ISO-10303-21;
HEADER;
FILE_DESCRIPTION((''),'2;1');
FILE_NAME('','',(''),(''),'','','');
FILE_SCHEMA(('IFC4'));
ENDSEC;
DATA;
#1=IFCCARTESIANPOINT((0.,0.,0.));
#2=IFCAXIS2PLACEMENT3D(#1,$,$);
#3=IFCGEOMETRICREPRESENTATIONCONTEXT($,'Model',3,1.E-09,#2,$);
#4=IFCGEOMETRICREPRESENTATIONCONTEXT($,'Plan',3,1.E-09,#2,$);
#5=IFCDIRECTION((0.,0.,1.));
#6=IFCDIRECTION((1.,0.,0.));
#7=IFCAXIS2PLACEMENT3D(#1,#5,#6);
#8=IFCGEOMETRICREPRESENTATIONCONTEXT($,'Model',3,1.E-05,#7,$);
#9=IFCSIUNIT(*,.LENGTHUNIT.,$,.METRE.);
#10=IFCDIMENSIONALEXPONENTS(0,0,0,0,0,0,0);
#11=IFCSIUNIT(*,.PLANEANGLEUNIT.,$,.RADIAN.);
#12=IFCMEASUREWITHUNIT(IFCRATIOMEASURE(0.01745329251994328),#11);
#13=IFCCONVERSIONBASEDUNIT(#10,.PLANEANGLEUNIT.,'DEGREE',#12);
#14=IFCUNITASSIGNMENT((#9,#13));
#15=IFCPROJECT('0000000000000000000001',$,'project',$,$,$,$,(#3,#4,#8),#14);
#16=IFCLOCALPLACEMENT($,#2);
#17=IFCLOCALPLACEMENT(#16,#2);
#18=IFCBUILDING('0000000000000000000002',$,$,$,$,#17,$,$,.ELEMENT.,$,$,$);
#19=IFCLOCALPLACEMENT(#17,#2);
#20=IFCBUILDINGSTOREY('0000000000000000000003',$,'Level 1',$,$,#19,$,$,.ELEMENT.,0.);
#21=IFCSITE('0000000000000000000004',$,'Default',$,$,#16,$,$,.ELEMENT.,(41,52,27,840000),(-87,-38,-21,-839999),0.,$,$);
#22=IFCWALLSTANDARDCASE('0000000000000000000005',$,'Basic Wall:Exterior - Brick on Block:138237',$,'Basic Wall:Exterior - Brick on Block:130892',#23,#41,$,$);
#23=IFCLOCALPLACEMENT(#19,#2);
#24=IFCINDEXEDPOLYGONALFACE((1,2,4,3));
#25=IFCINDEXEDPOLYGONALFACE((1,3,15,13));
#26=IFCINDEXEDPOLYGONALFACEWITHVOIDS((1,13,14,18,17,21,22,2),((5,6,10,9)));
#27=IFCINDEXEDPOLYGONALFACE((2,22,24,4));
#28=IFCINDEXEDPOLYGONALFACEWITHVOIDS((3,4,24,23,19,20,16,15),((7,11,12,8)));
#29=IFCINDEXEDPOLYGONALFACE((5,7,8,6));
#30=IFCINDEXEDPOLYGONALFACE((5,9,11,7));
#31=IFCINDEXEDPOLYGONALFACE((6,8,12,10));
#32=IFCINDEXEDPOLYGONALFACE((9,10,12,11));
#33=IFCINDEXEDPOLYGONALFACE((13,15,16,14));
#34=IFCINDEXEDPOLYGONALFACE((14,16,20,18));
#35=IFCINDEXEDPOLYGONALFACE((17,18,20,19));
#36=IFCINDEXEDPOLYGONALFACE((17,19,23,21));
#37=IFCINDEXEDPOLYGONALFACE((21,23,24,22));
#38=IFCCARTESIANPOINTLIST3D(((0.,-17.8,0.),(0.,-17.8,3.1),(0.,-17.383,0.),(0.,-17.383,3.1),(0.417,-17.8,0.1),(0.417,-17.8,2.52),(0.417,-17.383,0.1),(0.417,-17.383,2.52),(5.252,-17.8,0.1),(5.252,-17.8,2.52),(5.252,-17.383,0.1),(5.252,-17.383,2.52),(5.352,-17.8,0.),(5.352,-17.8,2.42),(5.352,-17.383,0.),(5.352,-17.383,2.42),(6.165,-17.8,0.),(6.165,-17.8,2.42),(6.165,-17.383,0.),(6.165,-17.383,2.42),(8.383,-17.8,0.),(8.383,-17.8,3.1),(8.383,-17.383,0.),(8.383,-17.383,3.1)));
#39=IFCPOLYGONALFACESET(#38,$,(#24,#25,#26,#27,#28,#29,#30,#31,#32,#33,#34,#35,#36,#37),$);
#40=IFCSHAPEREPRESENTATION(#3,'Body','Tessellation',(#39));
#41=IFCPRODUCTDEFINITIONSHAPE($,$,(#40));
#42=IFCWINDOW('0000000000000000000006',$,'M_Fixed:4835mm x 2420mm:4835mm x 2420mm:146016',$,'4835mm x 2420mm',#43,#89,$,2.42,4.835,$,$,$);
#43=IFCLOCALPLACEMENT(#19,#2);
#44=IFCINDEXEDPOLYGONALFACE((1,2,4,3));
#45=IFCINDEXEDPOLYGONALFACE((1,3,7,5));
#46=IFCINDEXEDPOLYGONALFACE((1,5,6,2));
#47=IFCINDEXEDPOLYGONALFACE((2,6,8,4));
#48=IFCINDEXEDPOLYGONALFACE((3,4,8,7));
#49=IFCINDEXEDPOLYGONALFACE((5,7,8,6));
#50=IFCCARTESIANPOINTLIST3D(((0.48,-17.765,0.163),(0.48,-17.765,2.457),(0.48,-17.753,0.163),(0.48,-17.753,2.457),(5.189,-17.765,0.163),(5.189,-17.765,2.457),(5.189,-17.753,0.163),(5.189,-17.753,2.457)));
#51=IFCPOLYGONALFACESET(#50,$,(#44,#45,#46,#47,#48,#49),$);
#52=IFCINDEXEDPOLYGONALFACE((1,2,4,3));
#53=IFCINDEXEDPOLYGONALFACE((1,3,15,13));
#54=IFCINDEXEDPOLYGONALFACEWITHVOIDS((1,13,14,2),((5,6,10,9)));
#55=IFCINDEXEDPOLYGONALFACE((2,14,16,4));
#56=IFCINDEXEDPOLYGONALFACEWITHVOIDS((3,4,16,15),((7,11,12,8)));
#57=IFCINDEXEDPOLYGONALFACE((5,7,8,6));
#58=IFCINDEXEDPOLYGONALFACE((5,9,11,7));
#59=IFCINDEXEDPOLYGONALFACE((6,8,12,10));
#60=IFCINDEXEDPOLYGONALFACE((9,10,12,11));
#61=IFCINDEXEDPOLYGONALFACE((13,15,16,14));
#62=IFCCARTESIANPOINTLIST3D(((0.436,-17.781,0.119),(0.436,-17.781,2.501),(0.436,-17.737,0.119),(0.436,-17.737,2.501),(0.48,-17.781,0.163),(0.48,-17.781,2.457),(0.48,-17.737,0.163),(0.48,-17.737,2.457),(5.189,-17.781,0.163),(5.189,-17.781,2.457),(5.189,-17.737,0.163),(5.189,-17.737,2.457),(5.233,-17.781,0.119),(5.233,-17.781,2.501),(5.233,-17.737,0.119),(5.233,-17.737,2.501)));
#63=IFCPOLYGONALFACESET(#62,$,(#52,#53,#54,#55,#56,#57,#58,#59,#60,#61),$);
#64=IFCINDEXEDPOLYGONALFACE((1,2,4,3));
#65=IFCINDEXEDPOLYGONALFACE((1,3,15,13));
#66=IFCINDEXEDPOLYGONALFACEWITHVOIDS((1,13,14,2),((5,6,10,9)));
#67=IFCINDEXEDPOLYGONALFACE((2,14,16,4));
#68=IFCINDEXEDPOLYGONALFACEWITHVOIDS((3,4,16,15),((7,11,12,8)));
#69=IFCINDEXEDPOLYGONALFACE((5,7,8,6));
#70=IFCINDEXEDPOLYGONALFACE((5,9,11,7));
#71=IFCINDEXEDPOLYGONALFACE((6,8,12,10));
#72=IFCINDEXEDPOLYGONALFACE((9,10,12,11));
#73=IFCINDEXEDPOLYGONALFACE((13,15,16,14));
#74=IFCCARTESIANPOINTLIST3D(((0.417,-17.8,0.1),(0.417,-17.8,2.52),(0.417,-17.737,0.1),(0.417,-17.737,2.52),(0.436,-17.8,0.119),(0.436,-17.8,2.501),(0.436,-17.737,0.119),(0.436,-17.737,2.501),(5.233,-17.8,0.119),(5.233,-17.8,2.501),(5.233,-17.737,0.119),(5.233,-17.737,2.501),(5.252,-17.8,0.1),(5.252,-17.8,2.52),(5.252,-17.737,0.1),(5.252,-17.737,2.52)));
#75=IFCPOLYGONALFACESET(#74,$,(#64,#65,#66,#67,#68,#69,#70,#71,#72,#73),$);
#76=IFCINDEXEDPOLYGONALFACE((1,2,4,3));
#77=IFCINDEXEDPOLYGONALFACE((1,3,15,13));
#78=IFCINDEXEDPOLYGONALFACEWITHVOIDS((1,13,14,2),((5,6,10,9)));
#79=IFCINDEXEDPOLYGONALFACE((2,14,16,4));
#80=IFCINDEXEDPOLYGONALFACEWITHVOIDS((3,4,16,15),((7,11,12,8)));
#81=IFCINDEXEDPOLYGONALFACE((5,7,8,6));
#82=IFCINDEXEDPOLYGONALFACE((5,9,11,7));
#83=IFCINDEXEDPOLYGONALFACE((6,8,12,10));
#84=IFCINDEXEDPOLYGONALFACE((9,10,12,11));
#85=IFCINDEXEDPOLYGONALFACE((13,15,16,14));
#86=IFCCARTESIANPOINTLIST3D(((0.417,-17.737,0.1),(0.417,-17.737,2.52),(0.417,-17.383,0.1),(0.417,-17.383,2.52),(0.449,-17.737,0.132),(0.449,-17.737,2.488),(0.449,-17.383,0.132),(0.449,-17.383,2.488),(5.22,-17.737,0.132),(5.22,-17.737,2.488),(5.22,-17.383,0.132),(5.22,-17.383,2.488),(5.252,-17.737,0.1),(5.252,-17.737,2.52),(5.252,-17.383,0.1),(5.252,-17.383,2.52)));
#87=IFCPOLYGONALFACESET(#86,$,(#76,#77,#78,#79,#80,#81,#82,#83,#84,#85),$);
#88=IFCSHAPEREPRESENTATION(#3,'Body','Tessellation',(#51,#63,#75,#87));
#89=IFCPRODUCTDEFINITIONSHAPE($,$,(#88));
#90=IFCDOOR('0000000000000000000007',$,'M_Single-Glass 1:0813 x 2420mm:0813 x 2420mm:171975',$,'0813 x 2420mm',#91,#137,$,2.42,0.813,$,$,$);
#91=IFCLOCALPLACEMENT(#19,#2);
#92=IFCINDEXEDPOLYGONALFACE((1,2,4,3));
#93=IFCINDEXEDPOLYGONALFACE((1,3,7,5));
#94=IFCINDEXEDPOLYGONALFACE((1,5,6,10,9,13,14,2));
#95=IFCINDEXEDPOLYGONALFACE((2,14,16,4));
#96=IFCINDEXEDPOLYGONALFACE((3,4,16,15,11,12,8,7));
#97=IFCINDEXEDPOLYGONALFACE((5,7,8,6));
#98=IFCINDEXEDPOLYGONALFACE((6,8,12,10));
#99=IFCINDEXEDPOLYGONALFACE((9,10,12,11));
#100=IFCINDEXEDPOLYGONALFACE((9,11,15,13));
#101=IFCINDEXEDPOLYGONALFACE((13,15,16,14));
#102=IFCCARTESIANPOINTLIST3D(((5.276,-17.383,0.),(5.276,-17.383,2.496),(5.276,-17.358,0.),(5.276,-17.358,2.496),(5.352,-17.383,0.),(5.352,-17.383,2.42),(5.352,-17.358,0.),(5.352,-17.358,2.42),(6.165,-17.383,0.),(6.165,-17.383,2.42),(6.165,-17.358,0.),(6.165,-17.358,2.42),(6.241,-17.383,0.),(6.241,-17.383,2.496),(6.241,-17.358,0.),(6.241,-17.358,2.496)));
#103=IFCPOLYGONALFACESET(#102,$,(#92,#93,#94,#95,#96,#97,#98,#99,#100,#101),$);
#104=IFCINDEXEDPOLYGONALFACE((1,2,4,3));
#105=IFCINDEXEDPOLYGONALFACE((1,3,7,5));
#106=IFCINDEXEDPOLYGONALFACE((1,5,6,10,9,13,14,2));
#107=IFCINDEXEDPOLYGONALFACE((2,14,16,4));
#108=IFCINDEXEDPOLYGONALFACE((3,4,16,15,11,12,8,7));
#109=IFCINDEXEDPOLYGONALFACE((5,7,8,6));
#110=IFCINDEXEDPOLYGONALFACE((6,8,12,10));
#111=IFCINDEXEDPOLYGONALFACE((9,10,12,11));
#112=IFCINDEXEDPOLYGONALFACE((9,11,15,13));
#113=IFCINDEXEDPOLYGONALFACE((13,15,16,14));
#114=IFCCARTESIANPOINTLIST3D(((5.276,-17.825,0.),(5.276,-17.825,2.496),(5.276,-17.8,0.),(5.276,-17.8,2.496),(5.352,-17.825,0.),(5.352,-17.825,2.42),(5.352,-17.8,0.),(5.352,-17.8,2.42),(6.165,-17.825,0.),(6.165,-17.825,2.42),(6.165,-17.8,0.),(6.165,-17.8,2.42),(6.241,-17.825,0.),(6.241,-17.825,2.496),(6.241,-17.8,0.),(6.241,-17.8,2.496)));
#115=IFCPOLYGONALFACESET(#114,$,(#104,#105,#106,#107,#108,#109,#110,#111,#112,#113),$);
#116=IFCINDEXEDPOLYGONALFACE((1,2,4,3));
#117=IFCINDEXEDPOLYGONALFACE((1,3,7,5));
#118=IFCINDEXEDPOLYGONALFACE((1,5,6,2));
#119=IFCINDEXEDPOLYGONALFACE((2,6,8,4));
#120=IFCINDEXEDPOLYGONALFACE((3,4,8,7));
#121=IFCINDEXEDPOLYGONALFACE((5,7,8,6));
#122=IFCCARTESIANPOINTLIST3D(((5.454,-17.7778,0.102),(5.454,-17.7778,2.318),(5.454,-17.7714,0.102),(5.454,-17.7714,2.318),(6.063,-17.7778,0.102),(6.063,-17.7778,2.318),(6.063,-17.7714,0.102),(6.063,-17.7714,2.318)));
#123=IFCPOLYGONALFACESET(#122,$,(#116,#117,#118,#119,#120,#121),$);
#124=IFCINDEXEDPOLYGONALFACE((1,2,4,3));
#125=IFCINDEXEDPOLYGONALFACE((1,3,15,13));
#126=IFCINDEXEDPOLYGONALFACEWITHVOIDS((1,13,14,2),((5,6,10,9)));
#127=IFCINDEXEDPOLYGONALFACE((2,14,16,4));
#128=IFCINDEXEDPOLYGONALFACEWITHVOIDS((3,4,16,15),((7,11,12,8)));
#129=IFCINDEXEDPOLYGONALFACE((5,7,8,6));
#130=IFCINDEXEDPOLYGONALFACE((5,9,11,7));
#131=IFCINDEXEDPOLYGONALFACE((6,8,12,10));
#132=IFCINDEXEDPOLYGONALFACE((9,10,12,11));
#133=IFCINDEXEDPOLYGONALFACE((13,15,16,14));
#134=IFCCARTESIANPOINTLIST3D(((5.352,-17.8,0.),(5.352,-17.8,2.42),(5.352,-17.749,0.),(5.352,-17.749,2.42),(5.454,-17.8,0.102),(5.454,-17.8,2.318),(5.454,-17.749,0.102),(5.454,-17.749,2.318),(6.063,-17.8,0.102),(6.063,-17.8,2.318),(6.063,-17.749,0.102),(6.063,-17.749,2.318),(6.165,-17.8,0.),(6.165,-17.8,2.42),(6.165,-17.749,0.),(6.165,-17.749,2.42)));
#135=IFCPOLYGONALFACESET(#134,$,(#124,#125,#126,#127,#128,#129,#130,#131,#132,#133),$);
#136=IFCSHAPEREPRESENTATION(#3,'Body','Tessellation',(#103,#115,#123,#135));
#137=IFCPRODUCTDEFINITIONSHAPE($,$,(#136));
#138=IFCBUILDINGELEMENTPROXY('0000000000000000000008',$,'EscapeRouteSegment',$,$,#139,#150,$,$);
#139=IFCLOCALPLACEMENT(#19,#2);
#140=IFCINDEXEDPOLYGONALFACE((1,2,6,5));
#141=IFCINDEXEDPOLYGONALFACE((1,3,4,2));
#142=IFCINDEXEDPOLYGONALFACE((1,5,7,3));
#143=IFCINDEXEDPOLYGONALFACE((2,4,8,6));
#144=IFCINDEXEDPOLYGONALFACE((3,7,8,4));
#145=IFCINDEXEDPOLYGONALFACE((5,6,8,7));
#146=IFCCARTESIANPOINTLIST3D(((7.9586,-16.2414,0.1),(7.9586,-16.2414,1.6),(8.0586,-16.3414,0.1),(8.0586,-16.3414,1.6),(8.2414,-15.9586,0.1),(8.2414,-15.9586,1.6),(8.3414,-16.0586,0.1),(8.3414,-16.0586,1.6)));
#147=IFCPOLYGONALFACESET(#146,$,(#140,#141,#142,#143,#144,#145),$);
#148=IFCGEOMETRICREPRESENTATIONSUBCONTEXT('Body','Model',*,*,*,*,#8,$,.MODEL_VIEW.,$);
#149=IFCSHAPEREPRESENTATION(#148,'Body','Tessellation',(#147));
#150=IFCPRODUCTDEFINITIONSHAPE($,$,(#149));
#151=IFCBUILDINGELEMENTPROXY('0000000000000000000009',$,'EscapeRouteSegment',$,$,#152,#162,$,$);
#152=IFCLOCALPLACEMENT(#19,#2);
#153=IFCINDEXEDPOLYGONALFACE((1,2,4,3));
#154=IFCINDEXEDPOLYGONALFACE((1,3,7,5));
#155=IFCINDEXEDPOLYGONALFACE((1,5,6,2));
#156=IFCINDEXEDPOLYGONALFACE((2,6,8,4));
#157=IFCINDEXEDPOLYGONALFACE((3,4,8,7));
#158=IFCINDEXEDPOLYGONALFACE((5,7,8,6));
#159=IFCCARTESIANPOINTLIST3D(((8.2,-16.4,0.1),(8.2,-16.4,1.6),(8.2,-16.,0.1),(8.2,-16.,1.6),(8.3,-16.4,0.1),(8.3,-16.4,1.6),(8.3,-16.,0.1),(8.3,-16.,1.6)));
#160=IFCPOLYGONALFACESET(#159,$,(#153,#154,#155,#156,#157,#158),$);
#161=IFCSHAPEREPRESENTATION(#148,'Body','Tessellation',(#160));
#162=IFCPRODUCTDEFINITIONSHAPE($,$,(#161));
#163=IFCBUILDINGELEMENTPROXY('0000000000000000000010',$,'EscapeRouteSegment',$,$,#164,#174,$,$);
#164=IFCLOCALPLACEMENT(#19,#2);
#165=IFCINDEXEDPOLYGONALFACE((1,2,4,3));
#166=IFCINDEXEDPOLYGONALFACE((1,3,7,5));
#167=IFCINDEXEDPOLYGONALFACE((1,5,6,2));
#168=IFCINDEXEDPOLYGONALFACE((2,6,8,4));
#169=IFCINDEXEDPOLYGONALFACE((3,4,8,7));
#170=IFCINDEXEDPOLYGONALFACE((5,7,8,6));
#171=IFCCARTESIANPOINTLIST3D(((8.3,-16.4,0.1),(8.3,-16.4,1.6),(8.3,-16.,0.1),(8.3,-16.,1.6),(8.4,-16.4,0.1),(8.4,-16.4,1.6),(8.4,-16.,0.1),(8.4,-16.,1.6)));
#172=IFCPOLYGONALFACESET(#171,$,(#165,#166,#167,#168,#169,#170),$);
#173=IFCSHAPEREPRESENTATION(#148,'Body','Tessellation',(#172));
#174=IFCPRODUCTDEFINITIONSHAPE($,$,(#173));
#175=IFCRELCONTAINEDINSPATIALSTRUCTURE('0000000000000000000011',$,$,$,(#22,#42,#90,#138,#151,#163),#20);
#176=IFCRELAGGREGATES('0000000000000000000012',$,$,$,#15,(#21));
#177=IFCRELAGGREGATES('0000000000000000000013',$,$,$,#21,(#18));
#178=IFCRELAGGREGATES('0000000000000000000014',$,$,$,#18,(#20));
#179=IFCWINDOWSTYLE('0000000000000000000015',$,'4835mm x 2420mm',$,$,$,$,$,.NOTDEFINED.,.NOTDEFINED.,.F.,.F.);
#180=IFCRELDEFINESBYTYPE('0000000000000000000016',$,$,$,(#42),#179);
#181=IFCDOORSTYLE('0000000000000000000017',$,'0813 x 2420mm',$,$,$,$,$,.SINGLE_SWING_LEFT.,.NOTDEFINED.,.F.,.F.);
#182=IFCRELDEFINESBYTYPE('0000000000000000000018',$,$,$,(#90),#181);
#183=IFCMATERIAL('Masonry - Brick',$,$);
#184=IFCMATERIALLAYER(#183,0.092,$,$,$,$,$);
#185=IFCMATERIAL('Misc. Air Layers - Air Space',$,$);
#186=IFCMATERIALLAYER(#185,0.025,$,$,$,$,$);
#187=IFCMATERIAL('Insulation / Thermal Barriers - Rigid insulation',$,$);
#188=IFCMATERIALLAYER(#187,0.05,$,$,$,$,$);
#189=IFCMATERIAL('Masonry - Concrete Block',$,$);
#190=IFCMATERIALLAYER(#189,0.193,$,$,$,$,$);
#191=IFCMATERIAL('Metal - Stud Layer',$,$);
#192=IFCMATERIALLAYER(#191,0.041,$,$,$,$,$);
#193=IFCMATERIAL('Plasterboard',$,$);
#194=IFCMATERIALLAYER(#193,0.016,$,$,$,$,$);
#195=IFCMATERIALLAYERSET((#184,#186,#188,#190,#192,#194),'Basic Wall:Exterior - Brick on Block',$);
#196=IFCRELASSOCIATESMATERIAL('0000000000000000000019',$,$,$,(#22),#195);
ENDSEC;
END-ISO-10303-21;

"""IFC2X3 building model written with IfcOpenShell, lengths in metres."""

from ifc_helpers import new_model, entity, si_unit, converted_unit, frame, frame_2d, origin, origin_with_axes, origin_2d_with_axis, place, context, subcontext, project, spatial, polyline, rectangle, outline, extrude, source, transform, mapped, material, layer, layer_set, layer_usage, type_object, type_shapes, element, fill, save


model = new_model("IFC2X3")

# Units and contexts
model_context_1 = context("Model", 3, precision=1e-09, world=origin())
plan_context = context("Plan", 3, precision=1e-09, world=origin())
model_context_2 = context("Model", 3, precision=1e-05, world=origin_with_axes())
body_context = subcontext(model_context_2, "Body", "Model", "MODEL_VIEW")
ifc_project = project(units=[si_unit("LENGTHUNIT", "METRE"), converted_unit("PLANEANGLEUNIT", "DEGREE", entity("IfcRatioMeasure", 0.01745329251994328), si_unit("PLANEANGLEUNIT", "RADIAN"), dimensions=[0, 0, 0, 0, 0, 0, 0])], contexts=[model_context_1, plan_context, model_context_2])

# Site, building, storey
site_placement = place(None, origin())
site = spatial("IfcSite", under=ifc_project, at=site_placement, Name="Default", CompositionType="ELEMENT", RefLatitude=(41, 52, 27, 840000), RefLongitude=(-87, -38, -21, -839999), RefElevation=0.0)
building_placement = place(site_placement, origin())
building = spatial("IfcBuilding", under=site, at=building_placement, CompositionType="ELEMENT")
storey_placement = place(building_placement, origin())
storey = spatial("IfcBuildingStorey", under=building, at=storey_placement, Name="Level 1", CompositionType="ELEMENT", Elevation=0.0)

# Wall, openings, window, door
ifc_material_1 = material(Name="Masonry - Brick")
ifc_layer_1 = layer(ifc_material_1, 0.092)
ifc_material_2 = material(Name="Misc. Air Layers - Air Space")
ifc_layer_2 = layer(ifc_material_2, 0.025)
ifc_material_3 = material(Name="Insulation / Thermal Barriers - Rigid insulation")
ifc_layer_3 = layer(ifc_material_3, 0.05)
ifc_material_4 = material(Name="Masonry - Concrete Block")
ifc_layer_4 = layer(ifc_material_4, 0.193)
ifc_material_5 = material(Name="Metal - Stud Layer")
ifc_layer_5 = layer(ifc_material_5, 0.041)
ifc_material_6 = material(Name="Plasterboard")
ifc_layer_6 = layer(ifc_material_6, 0.016)
ifc_layer_set = layer_set([ifc_layer_1, ifc_layer_2, ifc_layer_3, ifc_layer_4, ifc_layer_5, ifc_layer_6], Name="Basic Wall:Exterior - Brick on Block")
ifc_layer_usage = layer_usage(ifc_layer_set, "AXIS2", "NEGATIVE", 0.2085)
wall_placement = place(storey_placement, frame((8.383, -17.5915, 0.0), z_axis=(0.0, 0.0, 1.0), x_axis=(-1.0, 0.0, 0.0)))
wall = element("IfcWallStandardCase", 1, at=wall_placement, inside=storey, material=ifc_layer_usage, Name="Basic Wall:Exterior - Brick on Block:138237", ObjectType="Basic Wall:Exterior - Brick on Block:130892", context=model_context_1, shape_type="SweptSolid", body=[
    extrude(rectangle(XDim=8.383, YDim=0.417, at=frame_2d((4.1915, 0.0), x_axis=(-1.0, 0.0))), origin(), (0.0, 0.0, 1.0), 3.1),
])
opening_1_placement = place(wall_placement, frame((3.131, -0.2085, 0.1)))
opening_1 = element("IfcOpeningElement", 2, at=opening_1_placement, cuts=wall, ObjectType="Opening", context=model_context_1, shape_type="SweptSolid", body=[
    extrude(rectangle(XDim=2.42, YDim=4.835, at=frame_2d((1.21, 2.4175), x_axis=(1.0, 0.0))), frame((0.0, 0.0, 0.0), z_axis=(0.0, 1.0, 0.0), x_axis=(0.0, 0.0, 1.0)), (0.0, 0.0, 1.0), 0.417),
])
opening_2_placement = place(wall_placement, frame((2.218, -0.2085, 0.0)))
opening_2 = element("IfcOpeningElement", 3, at=opening_2_placement, cuts=wall, ObjectType="Opening", context=model_context_1, shape_type="SweptSolid", body=[
    extrude(rectangle(XDim=0.813, YDim=2.42, at=frame_2d((1.21, 0.4065), x_axis=(0.0, -1.0))), frame((0.0, 0.0, 0.0), z_axis=(0.0, 1.0, 0.0), x_axis=(0.0, 0.0, 1.0)), (0.0, 0.0, 1.0), 0.417),
])
window_style = type_object("IfcWindowStyle", Name="4835mm x 2420mm", ConstructionType="NOTDEFINED", OperationType="NOTDEFINED", ParameterTakesPrecedence=False, Sizeable=False)
shared_shape_1 = source(origin(), model_context_1, "Body", "SweptSolid", [
    extrude(rectangle(XDim=0.012, YDim=4.709, at=origin_2d_with_axis()), frame((2.4175, 0.376, 0.063), z_axis=(0.0, 0.0, 1.0), x_axis=(0.0, -1.0, 0.0)), (0.0, 0.0, 1.0), 2.294),
    extrude(outline(polyline([(-2.3985, -1.191), (2.3985, -1.191), (2.3985, 1.191), (-2.3985, 1.191), (-2.3985, -1.191)]), holes=[polyline([(-2.3545, -1.147), (-2.3545, 1.147), (2.3545, 1.147), (2.3545, -1.147), (-2.3545, -1.147)])]), frame((2.4175, 0.354, 1.21), z_axis=(0.0, 1.0, 0.0), x_axis=(1.0, 0.0, 0.0)), (0.0, 0.0, 1.0), 0.044),
    extrude(outline(polyline([(-2.4175, -1.21), (2.4175, -1.21), (2.4175, 1.21), (-2.4175, 1.21), (-2.4175, -1.21)]), holes=[polyline([(-2.3985, -1.191), (-2.3985, 1.191), (2.3985, 1.191), (2.3985, -1.191), (-2.3985, -1.191)])]), frame((2.4175, 0.354, 1.21), z_axis=(0.0, 1.0, 0.0), x_axis=(1.0, 0.0, 0.0)), (0.0, 0.0, 1.0), 0.063),
    extrude(outline(polyline([(-2.4175, -1.21), (2.4175, -1.21), (2.4175, 1.21), (-2.4175, 1.21), (-2.4175, -1.21)]), holes=[polyline([(-2.3855, -1.178), (-2.3855, 1.178), (2.3855, 1.178), (2.3855, -1.178), (-2.3855, -1.178)])]), frame((2.4175, 0.0, 1.21), z_axis=(0.0, 1.0, 0.0), x_axis=(1.0, 0.0, 0.0)), (0.0, 0.0, 1.0), 0.354),
])
type_shapes(window_style, [shared_shape_1])
window_placement = place(opening_1_placement, origin())
window = element("IfcWindow", 4, at=window_placement, inside=storey, type_object=window_style, Name="M_Fixed:4835mm x 2420mm:4835mm x 2420mm:146016", ObjectType="4835mm x 2420mm", OverallHeight=2.42, OverallWidth=4.835, context=model_context_1, shape_type="MappedRepresentation", body=[
    mapped(shared_shape_1, transform((0.0, 0.0, 0.0), scale=1.0)),
])
fill(opening_1, window)
door_style = type_object("IfcDoorStyle", Name="0813 x 2420mm", ConstructionType="NOTDEFINED", OperationType="SINGLE_SWING_LEFT", ParameterTakesPrecedence=False, Sizeable=False)
shared_shape_2 = source(origin(), model_context_1, "Body", "SweptSolid", [
    extrude(outline(polyline([(-0.4065, -1.191), (-0.4065, 1.229), (-0.4825, 1.229), (-0.4825, -1.267), (0.4825, -1.267), (0.4825, 1.229), (0.4065, 1.229), (0.4065, -1.191), (-0.4065, -1.191)])), frame((0.4065, 0.0, 1.229), z_axis=(0.0, 1.0, 0.0), x_axis=(1.0, 0.0, 0.0)), (0.0, 0.0, -1.0), 0.025),
    extrude(outline(polyline([(-0.4065, -1.191), (-0.4065, 1.229), (-0.4825, 1.229), (-0.4825, -1.267), (0.4825, -1.267), (0.4825, 1.229), (0.4065, 1.229), (0.4065, -1.191), (-0.4065, -1.191)])), frame((0.4065, 0.442, 1.229), z_axis=(0.0, 1.0, 0.0), x_axis=(1.0, 0.0, 0.0)), (0.0, 0.0, -1.0), 0.025),
    extrude(rectangle(XDim=0.609, YDim=0.0064, at=origin_2d_with_axis()), frame((0.4065, 0.3916, 0.102)), (0.0, 0.0, 1.0), 2.216),
    extrude(outline(polyline([(-1.21, -0.4065), (1.21, -0.4065), (1.21, 0.4065), (-1.21, 0.4065), (-1.21, -0.4065)]), holes=[polyline([(-1.108, 0.3045), (1.108, 0.3045), (1.108, -0.3045), (-1.108, -0.3045), (-1.108, 0.3045)])]), frame((0.4065, 0.417, 1.21), z_axis=(0.0, -1.0, 0.0), x_axis=(0.0, 0.0, -1.0)), (0.0, 0.0, 1.0), 0.051),
])
type_shapes(door_style, [shared_shape_2])
door_placement = place(opening_2_placement, origin())
door = element("IfcDoor", 5, at=door_placement, inside=storey, type_object=door_style, Name="M_Single-Glass 1:0813 x 2420mm:0813 x 2420mm:171975", ObjectType="0813 x 2420mm", OverallHeight=2.42, OverallWidth=0.813, context=model_context_1, shape_type="MappedRepresentation", body=[
    mapped(shared_shape_2, transform((0.0, 0.0, 0.0), scale=1.0)),
])
fill(opening_2, door)

# Building element proxies
proxy_1_placement = place(storey_placement, frame((8.1, -16.1, 0.1), z_axis=(0.0, 0.0, 1.0), x_axis=(0.707103, -0.70711, 0.0)))
element("IfcBuildingElementProxy", 6, at=proxy_1_placement, inside=storey, Name="EscapeRouteSegment", context=body_context, shape_type="SweptSolid", body=[
    extrude(outline(polyline([(0.0, -0.2), (0.0, 0.2), (0.1414, 0.2), (0.1414, -0.2), (0.0, -0.2)])), origin_with_axes(), (0.0, 0.0, 1.0), 1.5),
])
proxy_2_placement = place(storey_placement, frame((8.2, -16.2, 0.1), z_axis=(0.0, 0.0, 1.0), x_axis=(1.0, 0.0, 0.0)))
element("IfcBuildingElementProxy", 7, at=proxy_2_placement, inside=storey, Name="EscapeRouteSegment", context=body_context, shape_type="SweptSolid", body=[
    extrude(outline(polyline([(0.0, -0.2), (0.0, 0.2), (0.1, 0.2), (0.1, -0.2), (0.0, -0.2)])), origin_with_axes(), (0.0, 0.0, 1.0), 1.5),
])
proxy_3_placement = place(storey_placement, frame((8.3, -16.2, 0.1), z_axis=(0.0, 0.0, 1.0), x_axis=(1.0, 0.0, 0.0)))
element("IfcBuildingElementProxy", 8, at=proxy_3_placement, inside=storey, Name="EscapeRouteSegment", context=body_context, shape_type="SweptSolid", body=[
    extrude(outline(polyline([(0.0, -0.2), (0.0, 0.2), (0.1, 0.2), (0.1, -0.2), (0.0, -0.2)])), origin_with_axes(), (0.0, 0.0, 1.0), 1.5),
])

save(model, "model.ifc")
